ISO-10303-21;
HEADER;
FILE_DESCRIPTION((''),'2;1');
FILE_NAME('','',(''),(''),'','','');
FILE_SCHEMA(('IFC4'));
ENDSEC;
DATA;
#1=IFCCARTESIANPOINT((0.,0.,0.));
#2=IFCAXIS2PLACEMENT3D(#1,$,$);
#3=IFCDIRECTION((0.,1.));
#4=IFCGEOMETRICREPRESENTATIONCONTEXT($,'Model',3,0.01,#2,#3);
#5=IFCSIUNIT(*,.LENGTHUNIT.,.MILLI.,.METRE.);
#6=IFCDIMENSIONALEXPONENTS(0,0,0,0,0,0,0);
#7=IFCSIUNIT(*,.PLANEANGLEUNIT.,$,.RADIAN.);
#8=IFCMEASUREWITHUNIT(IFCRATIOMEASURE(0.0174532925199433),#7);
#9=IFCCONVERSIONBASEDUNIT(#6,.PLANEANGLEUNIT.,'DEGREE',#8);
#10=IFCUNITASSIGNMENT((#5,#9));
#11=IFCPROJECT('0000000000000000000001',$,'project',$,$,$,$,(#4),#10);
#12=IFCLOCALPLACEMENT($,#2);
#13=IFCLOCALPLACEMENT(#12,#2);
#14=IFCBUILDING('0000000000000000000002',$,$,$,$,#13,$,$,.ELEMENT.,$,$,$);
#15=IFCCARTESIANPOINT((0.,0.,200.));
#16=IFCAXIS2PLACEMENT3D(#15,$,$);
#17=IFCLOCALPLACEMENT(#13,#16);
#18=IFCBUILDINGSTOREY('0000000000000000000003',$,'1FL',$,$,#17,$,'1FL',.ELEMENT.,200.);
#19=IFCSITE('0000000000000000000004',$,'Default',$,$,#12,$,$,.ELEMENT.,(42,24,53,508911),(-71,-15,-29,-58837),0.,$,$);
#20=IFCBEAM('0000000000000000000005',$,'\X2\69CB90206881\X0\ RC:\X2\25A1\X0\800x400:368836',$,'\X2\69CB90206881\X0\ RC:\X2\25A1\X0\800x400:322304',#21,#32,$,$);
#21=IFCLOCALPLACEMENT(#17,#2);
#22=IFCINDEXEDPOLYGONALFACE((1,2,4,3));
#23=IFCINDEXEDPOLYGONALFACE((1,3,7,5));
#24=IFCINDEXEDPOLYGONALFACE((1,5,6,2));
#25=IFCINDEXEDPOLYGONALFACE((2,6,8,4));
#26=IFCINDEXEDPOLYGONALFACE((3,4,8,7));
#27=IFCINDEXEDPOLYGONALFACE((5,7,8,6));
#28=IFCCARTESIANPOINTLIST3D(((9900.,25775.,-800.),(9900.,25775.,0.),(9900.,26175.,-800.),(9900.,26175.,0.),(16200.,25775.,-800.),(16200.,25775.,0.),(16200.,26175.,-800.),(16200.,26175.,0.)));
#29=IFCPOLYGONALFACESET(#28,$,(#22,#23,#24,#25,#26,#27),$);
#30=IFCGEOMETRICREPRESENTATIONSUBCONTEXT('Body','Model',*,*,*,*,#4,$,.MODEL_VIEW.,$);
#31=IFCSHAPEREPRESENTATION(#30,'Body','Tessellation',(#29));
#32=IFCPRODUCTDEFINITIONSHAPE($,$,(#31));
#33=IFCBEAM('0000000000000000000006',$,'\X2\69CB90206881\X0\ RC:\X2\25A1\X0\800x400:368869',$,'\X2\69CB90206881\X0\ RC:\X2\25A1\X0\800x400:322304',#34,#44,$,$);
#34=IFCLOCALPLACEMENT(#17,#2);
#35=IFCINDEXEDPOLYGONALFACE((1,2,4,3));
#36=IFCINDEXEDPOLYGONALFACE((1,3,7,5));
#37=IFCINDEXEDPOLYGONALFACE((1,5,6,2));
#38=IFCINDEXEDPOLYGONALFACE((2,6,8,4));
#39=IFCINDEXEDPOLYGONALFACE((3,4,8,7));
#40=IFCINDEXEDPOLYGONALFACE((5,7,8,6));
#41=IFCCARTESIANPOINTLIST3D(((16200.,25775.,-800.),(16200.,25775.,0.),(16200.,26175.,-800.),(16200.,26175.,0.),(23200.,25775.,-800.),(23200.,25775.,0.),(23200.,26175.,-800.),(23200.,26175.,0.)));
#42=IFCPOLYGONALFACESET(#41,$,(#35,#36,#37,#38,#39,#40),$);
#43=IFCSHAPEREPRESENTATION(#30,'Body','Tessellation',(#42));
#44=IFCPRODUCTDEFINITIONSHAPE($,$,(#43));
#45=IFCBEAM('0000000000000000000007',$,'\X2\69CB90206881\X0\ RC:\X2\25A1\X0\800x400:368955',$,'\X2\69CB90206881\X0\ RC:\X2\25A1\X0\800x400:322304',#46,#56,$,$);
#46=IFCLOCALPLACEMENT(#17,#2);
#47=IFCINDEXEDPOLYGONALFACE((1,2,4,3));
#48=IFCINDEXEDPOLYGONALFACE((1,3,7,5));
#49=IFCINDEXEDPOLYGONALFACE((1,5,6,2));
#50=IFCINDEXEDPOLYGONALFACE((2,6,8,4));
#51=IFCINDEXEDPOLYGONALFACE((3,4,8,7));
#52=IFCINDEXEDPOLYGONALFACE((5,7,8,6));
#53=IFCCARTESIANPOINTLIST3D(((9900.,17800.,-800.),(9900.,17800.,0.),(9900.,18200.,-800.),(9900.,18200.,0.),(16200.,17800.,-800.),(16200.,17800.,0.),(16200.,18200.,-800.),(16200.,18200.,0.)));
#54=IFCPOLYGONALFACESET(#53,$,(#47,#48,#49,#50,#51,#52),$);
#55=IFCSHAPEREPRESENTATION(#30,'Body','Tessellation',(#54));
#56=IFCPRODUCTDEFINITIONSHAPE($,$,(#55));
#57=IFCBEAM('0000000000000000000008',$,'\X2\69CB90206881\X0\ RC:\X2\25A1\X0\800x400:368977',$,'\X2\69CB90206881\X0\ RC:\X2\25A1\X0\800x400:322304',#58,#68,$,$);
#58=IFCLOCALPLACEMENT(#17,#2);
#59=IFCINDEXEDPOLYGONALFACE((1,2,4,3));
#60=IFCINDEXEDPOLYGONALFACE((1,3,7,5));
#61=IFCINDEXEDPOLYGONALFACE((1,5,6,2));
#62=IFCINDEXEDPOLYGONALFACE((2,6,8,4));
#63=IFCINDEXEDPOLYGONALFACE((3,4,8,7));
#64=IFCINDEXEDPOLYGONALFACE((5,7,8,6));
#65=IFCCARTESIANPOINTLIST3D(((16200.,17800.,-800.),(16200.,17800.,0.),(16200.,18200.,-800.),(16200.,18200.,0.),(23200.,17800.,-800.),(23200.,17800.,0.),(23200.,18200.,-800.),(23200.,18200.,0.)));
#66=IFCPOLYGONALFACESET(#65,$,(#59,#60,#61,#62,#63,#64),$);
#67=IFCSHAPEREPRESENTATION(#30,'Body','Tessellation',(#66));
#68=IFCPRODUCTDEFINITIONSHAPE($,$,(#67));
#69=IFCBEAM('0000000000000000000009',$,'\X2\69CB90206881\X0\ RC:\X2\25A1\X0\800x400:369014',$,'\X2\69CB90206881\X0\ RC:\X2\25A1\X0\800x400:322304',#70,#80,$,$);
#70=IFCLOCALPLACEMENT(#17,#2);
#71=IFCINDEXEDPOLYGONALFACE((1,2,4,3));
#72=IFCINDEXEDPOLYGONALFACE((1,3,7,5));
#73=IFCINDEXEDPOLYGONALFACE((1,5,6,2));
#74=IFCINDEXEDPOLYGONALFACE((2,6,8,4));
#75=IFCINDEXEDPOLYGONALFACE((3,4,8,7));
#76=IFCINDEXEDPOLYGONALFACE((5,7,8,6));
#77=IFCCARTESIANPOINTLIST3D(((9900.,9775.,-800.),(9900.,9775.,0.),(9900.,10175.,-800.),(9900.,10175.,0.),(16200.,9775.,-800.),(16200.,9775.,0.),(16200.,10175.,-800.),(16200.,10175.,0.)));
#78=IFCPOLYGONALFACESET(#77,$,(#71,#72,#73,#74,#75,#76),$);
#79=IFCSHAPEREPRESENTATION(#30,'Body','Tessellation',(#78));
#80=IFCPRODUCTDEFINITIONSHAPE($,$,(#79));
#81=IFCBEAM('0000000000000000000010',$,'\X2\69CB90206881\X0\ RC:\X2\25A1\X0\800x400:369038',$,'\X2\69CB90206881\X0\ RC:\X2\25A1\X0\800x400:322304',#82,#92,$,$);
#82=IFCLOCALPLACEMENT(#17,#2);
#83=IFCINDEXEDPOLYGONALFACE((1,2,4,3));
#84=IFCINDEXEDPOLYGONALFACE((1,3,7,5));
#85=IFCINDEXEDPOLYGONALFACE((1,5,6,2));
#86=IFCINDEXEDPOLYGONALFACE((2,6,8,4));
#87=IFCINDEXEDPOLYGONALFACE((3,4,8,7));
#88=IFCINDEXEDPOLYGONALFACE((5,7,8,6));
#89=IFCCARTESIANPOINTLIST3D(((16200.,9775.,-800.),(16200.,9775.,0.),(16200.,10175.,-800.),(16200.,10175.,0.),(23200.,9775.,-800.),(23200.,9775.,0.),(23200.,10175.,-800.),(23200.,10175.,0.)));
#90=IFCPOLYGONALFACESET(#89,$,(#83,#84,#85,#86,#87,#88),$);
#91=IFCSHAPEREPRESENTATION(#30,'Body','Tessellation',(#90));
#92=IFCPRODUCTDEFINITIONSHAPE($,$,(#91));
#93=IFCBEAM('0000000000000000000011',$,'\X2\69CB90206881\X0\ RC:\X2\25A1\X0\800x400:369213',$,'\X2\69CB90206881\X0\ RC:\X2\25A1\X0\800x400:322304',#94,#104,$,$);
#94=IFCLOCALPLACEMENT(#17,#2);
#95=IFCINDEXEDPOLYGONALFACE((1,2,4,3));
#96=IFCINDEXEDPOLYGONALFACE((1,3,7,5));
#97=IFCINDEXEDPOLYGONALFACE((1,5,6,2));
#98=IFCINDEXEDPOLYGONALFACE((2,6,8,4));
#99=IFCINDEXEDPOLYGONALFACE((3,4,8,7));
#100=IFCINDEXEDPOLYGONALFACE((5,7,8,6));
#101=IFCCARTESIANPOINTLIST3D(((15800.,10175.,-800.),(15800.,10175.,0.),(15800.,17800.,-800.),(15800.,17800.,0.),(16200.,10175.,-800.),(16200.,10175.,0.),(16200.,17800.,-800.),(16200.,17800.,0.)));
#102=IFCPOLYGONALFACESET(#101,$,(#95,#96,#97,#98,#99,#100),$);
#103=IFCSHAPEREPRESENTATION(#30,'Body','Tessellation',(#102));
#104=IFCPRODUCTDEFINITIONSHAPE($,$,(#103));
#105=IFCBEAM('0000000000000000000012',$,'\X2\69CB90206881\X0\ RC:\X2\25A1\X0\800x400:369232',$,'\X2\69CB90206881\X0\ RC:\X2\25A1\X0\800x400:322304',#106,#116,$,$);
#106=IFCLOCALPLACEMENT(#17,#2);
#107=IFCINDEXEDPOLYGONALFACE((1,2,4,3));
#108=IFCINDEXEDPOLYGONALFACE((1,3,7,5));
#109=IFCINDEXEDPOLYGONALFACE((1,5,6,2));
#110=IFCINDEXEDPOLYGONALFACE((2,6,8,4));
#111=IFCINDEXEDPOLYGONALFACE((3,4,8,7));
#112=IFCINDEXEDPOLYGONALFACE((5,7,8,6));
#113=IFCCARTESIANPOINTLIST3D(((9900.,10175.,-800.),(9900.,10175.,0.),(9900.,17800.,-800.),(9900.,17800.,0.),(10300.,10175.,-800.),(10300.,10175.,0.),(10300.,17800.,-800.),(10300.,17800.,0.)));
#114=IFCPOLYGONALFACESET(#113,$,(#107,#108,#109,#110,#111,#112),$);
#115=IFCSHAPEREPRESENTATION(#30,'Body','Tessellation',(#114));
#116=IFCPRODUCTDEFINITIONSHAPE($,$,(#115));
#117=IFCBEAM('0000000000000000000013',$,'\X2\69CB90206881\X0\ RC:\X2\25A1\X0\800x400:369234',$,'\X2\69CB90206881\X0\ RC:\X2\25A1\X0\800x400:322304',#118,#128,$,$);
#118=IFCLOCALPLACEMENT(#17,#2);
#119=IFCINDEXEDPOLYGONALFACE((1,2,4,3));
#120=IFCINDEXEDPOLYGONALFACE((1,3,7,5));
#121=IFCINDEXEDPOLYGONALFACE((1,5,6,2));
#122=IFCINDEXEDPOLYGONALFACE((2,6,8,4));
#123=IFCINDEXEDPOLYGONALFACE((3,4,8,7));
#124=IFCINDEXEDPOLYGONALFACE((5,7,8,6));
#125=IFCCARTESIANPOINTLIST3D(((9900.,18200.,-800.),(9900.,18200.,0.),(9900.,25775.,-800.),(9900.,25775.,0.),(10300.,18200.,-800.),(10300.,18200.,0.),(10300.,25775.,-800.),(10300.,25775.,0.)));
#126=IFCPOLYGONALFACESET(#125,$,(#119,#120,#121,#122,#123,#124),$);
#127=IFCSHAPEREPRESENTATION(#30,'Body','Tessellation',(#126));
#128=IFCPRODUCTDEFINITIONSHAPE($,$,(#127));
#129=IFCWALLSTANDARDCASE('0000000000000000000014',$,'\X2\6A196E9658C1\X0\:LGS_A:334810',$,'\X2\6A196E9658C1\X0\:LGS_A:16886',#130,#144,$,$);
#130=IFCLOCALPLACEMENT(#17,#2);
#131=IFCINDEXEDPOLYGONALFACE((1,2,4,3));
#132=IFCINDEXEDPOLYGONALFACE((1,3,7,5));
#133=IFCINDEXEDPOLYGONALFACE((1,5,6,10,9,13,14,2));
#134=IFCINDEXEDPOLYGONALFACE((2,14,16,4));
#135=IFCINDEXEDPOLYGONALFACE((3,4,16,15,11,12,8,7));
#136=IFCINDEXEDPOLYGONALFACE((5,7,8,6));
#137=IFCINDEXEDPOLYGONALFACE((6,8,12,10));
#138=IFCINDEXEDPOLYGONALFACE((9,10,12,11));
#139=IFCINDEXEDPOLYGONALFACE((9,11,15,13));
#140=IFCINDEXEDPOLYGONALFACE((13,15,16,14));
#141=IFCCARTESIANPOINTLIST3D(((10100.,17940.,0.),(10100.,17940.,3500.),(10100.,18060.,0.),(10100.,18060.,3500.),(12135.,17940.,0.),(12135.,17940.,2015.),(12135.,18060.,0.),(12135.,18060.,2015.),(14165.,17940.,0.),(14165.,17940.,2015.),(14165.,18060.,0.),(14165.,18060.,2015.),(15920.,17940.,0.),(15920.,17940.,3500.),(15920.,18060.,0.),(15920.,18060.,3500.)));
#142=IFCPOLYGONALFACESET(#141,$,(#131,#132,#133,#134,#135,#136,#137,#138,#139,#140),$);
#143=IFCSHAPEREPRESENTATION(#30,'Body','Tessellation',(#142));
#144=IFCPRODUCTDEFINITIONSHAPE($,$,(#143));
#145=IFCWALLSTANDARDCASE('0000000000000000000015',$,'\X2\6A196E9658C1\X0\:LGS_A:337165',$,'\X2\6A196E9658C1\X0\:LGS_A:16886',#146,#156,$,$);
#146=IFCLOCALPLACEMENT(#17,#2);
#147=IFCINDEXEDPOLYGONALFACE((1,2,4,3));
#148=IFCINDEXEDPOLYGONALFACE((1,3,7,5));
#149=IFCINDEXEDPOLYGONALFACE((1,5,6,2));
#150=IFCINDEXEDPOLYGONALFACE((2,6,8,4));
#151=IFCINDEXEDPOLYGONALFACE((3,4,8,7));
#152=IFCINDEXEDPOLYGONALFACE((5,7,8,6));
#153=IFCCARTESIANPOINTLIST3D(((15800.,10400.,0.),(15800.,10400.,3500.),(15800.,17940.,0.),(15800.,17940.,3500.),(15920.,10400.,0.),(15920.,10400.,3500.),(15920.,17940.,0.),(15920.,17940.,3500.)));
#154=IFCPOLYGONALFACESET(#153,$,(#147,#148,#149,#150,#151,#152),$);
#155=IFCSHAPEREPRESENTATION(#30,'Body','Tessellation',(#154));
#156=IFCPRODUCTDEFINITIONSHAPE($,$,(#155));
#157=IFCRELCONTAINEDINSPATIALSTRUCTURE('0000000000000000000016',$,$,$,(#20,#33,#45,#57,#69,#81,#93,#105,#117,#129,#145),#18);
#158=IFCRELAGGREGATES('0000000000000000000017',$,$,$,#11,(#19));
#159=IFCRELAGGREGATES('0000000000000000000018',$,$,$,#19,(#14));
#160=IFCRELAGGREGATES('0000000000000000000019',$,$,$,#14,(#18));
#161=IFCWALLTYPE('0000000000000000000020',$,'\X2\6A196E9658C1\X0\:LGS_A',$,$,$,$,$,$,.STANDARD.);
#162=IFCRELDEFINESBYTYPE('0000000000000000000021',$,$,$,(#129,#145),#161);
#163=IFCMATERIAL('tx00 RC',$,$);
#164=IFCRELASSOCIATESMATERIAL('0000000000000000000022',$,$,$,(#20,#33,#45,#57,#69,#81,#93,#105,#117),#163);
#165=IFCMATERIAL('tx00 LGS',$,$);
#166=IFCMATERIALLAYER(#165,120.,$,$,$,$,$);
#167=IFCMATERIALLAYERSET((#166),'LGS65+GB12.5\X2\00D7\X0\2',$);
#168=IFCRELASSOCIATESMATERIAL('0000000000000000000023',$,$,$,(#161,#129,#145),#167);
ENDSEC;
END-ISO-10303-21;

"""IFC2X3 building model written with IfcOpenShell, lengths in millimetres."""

from ifc_helpers import new_model, entity, si_unit, converted_unit, direction, frame, frame_2d, origin, place, context, subcontext, project, spatial, rectangle, extrude, material, layer, layer_set, layer_usage, type_object, element, save


model = new_model("IFC2X3")

# Units and contexts
model_context = context("Model", 3, precision=0.01, world=origin(), true_north=direction((0.0, 1.0)))
body_context = subcontext(model_context, "Body", "Model", "MODEL_VIEW")
ifc_project = project(units=[si_unit("LENGTHUNIT", "METRE", prefix="MILLI"), converted_unit("PLANEANGLEUNIT", "DEGREE", entity("IfcRatioMeasure", 0.0174532925199433), si_unit("PLANEANGLEUNIT", "RADIAN"), dimensions=[0, 0, 0, 0, 0, 0, 0])], contexts=[model_context])

# Site, building, storey
site_placement = place(None, origin())
site = spatial("IfcSite", under=ifc_project, at=site_placement, Name="Default", CompositionType="ELEMENT", RefLatitude=(42, 24, 53, 508911), RefLongitude=(-71, -15, -29, -58837), RefElevation=0.0)
building_placement = place(site_placement, origin())
building = spatial("IfcBuilding", under=site, at=building_placement, CompositionType="ELEMENT")
storey_placement = place(building_placement, frame((0.0, 0.0, 200.0)))
storey = spatial("IfcBuildingStorey", under=building, at=storey_placement, Name="1FL", LongName="1FL", CompositionType="ELEMENT", Elevation=200.0)

# Shared definitions
ifc_material_1 = material(Name="tx00 RC")

# Beams
beam_1_placement = place(storey_placement, frame((10100.0, 25975.0, 0.0)))
element("IfcBeam", 1, at=beam_1_placement, inside=storey, material=ifc_material_1, Name="構造梁 RC:□800x400:368836", ObjectType="構造梁 RC:□800x400:322304", context=body_context, shape_type="SweptSolid", body=[
    extrude(rectangle(XDim=800.0, YDim=400.0, at=frame_2d((0.0, 0.0), x_axis=(1.0, 0.0))), frame((-200.0, 0.0, -400.0), z_axis=(1.0, 0.0, 0.0), x_axis=(0.0, 0.0, -1.0)), (0.0, 0.0, 1.0), 6300.0),
])
beam_2_placement = place(storey_placement, frame((16000.0, 25975.0, 0.0)))
element("IfcBeam", 2, at=beam_2_placement, inside=storey, material=ifc_material_1, Name="構造梁 RC:□800x400:368869", ObjectType="構造梁 RC:□800x400:322304", context=body_context, shape_type="SweptSolid", body=[
    extrude(rectangle(XDim=800.0, YDim=400.0, at=frame_2d((0.0, 0.0), x_axis=(1.0, 0.0))), frame((200.0, 0.0, -400.0), z_axis=(1.0, 0.0, 0.0), x_axis=(0.0, 0.0, -1.0)), (0.0, 0.0, 1.0), 7000.0),
])
beam_3_placement = place(storey_placement, frame((10100.0, 18000.0, 0.0)))
element("IfcBeam", 3, at=beam_3_placement, inside=storey, material=ifc_material_1, Name="構造梁 RC:□800x400:368955", ObjectType="構造梁 RC:□800x400:322304", context=body_context, shape_type="SweptSolid", body=[
    extrude(rectangle(XDim=800.0, YDim=400.0, at=frame_2d((0.0, 0.0), x_axis=(1.0, 0.0))), frame((-200.0, 0.0, -400.0), z_axis=(1.0, 0.0, 0.0), x_axis=(0.0, 0.0, -1.0)), (0.0, 0.0, 1.0), 6300.0),
])
beam_4_placement = place(storey_placement, frame((16000.0, 18000.0, 0.0)))
element("IfcBeam", 4, at=beam_4_placement, inside=storey, material=ifc_material_1, Name="構造梁 RC:□800x400:368977", ObjectType="構造梁 RC:□800x400:322304", context=body_context, shape_type="SweptSolid", body=[
    extrude(rectangle(XDim=800.0, YDim=400.0, at=frame_2d((0.0, 0.0), x_axis=(1.0, 0.0))), frame((200.0, 0.0, -400.0), z_axis=(1.0, 0.0, 0.0), x_axis=(0.0, 0.0, -1.0)), (0.0, 0.0, 1.0), 7000.0),
])
beam_5_placement = place(storey_placement, frame((10100.0, 9975.0, 0.0)))
element("IfcBeam", 5, at=beam_5_placement, inside=storey, material=ifc_material_1, Name="構造梁 RC:□800x400:369014", ObjectType="構造梁 RC:□800x400:322304", context=body_context, shape_type="SweptSolid", body=[
    extrude(rectangle(XDim=800.0, YDim=400.0, at=frame_2d((0.0, 0.0), x_axis=(1.0, 0.0))), frame((-200.0, 0.0, -400.0), z_axis=(1.0, 0.0, 0.0), x_axis=(0.0, 0.0, -1.0)), (0.0, 0.0, 1.0), 6300.0),
])
beam_6_placement = place(storey_placement, frame((16000.0, 9975.0, 0.0)))
element("IfcBeam", 6, at=beam_6_placement, inside=storey, material=ifc_material_1, Name="構造梁 RC:□800x400:369038", ObjectType="構造梁 RC:□800x400:322304", context=body_context, shape_type="SweptSolid", body=[
    extrude(rectangle(XDim=800.0, YDim=400.0, at=frame_2d((0.0, 0.0), x_axis=(1.0, 0.0))), frame((200.0, 0.0, -400.0), z_axis=(1.0, 0.0, 0.0), x_axis=(0.0, 0.0, -1.0)), (0.0, 0.0, 1.0), 7000.0),
])
beam_7_placement = place(storey_placement, frame((16000.0, 9975.0, 0.0), z_axis=(0.0, 0.0, 1.0), x_axis=(0.0, 1.0, 0.0)))
element("IfcBeam", 7, at=beam_7_placement, inside=storey, material=ifc_material_1, Name="構造梁 RC:□800x400:369213", ObjectType="構造梁 RC:□800x400:322304", context=body_context, shape_type="SweptSolid", body=[
    extrude(rectangle(XDim=800.0, YDim=400.0, at=frame_2d((0.0, 0.0), x_axis=(1.0, 0.0))), frame((200.0, 0.0, -400.0), z_axis=(1.0, 0.0, 0.0), x_axis=(0.0, 0.0, -1.0)), (0.0, 0.0, 1.0), 7625.0),
])
beam_8_placement = place(storey_placement, frame((10100.0, 9975.0, 0.0), z_axis=(0.0, 0.0, 1.0), x_axis=(0.0, 1.0, 0.0)))
element("IfcBeam", 8, at=beam_8_placement, inside=storey, material=ifc_material_1, Name="構造梁 RC:□800x400:369232", ObjectType="構造梁 RC:□800x400:322304", context=body_context, shape_type="SweptSolid", body=[
    extrude(rectangle(XDim=800.0, YDim=400.0, at=frame_2d((0.0, 0.0), x_axis=(1.0, 0.0))), frame((200.0, 0.0, -400.0), z_axis=(1.0, 0.0, 0.0), x_axis=(0.0, 0.0, -1.0)), (0.0, 0.0, 1.0), 7625.0),
])
beam_9_placement = place(storey_placement, frame((10100.0, 18000.0, 0.0), z_axis=(0.0, 0.0, 1.0), x_axis=(0.0, 1.0, 0.0)))
element("IfcBeam", 9, at=beam_9_placement, inside=storey, material=ifc_material_1, Name="構造梁 RC:□800x400:369234", ObjectType="構造梁 RC:□800x400:322304", context=body_context, shape_type="SweptSolid", body=[
    extrude(rectangle(XDim=800.0, YDim=400.0, at=frame_2d((0.0, 0.0), x_axis=(1.0, 0.0))), frame((200.0, 0.0, -400.0), z_axis=(1.0, 0.0, 0.0), x_axis=(0.0, 0.0, -1.0)), (0.0, 0.0, 1.0), 7575.0),
])

# Wall, opening
ifc_material_2 = material(Name="tx00 LGS")
ifc_layer = layer(ifc_material_2, 120.0)
ifc_layer_set = layer_set([ifc_layer], Name="LGS65+GB12.5×2")
ifc_layer_usage_1 = layer_usage(ifc_layer_set, "AXIS2", "NEGATIVE", 60.0)
wall_type = type_object("IfcWallType", Name="標準壁:LGS_A", PredefinedType="STANDARD", material=ifc_layer_set)
wall_1_placement = place(storey_placement, frame((10100.0, 18000.0, 0.0)))
wall_1 = element("IfcWallStandardCase", 10, at=wall_1_placement, inside=storey, type_object=wall_type, material=ifc_layer_usage_1, Name="標準壁:LGS_A:334810", ObjectType="標準壁:LGS_A:16886", context=body_context, shape_type="SweptSolid", body=[
    extrude(rectangle(XDim=5820.0, YDim=120.0, at=frame_2d((2910.0, 0.0), x_axis=(-1.0, 0.0))), origin(), (0.0, 0.0, 1.0), 3500.0),
])
opening_placement = place(wall_1_placement, frame((2035.0, -60.0, 0.0)))
element("IfcOpeningElement", 11, at=opening_placement, cuts=wall_1, ObjectType="Opening", context=body_context, shape_type="SweptSolid", body=[
    extrude(rectangle(XDim=2015.0, YDim=2030.0, at=frame_2d((1007.5, 1015.0), x_axis=(1.0, 0.0))), frame((0.0, 0.0, 0.0), z_axis=(0.0, 1.0, 0.0), x_axis=(0.0, 0.0, 1.0)), (0.0, 0.0, 1.0), 120.0),
])

# Wall
ifc_layer_usage_2 = layer_usage(ifc_layer_set, "AXIS2", "NEGATIVE", 60.0)
wall_2_placement = place(storey_placement, frame((15860.0, 10400.0, 0.0), z_axis=(0.0, 0.0, 1.0), x_axis=(0.0, 1.0, 0.0)))
element("IfcWallStandardCase", 12, at=wall_2_placement, inside=storey, type_object=wall_type, material=ifc_layer_usage_2, Name="標準壁:LGS_A:337165", ObjectType="標準壁:LGS_A:16886", context=body_context, shape_type="SweptSolid", body=[
    extrude(rectangle(XDim=7540.0, YDim=120.0, at=frame_2d((3770.0, 0.0), x_axis=(-1.0, 0.0))), origin(), (0.0, 0.0, 1.0), 3500.0),
])

save(model, "model.ifc")
